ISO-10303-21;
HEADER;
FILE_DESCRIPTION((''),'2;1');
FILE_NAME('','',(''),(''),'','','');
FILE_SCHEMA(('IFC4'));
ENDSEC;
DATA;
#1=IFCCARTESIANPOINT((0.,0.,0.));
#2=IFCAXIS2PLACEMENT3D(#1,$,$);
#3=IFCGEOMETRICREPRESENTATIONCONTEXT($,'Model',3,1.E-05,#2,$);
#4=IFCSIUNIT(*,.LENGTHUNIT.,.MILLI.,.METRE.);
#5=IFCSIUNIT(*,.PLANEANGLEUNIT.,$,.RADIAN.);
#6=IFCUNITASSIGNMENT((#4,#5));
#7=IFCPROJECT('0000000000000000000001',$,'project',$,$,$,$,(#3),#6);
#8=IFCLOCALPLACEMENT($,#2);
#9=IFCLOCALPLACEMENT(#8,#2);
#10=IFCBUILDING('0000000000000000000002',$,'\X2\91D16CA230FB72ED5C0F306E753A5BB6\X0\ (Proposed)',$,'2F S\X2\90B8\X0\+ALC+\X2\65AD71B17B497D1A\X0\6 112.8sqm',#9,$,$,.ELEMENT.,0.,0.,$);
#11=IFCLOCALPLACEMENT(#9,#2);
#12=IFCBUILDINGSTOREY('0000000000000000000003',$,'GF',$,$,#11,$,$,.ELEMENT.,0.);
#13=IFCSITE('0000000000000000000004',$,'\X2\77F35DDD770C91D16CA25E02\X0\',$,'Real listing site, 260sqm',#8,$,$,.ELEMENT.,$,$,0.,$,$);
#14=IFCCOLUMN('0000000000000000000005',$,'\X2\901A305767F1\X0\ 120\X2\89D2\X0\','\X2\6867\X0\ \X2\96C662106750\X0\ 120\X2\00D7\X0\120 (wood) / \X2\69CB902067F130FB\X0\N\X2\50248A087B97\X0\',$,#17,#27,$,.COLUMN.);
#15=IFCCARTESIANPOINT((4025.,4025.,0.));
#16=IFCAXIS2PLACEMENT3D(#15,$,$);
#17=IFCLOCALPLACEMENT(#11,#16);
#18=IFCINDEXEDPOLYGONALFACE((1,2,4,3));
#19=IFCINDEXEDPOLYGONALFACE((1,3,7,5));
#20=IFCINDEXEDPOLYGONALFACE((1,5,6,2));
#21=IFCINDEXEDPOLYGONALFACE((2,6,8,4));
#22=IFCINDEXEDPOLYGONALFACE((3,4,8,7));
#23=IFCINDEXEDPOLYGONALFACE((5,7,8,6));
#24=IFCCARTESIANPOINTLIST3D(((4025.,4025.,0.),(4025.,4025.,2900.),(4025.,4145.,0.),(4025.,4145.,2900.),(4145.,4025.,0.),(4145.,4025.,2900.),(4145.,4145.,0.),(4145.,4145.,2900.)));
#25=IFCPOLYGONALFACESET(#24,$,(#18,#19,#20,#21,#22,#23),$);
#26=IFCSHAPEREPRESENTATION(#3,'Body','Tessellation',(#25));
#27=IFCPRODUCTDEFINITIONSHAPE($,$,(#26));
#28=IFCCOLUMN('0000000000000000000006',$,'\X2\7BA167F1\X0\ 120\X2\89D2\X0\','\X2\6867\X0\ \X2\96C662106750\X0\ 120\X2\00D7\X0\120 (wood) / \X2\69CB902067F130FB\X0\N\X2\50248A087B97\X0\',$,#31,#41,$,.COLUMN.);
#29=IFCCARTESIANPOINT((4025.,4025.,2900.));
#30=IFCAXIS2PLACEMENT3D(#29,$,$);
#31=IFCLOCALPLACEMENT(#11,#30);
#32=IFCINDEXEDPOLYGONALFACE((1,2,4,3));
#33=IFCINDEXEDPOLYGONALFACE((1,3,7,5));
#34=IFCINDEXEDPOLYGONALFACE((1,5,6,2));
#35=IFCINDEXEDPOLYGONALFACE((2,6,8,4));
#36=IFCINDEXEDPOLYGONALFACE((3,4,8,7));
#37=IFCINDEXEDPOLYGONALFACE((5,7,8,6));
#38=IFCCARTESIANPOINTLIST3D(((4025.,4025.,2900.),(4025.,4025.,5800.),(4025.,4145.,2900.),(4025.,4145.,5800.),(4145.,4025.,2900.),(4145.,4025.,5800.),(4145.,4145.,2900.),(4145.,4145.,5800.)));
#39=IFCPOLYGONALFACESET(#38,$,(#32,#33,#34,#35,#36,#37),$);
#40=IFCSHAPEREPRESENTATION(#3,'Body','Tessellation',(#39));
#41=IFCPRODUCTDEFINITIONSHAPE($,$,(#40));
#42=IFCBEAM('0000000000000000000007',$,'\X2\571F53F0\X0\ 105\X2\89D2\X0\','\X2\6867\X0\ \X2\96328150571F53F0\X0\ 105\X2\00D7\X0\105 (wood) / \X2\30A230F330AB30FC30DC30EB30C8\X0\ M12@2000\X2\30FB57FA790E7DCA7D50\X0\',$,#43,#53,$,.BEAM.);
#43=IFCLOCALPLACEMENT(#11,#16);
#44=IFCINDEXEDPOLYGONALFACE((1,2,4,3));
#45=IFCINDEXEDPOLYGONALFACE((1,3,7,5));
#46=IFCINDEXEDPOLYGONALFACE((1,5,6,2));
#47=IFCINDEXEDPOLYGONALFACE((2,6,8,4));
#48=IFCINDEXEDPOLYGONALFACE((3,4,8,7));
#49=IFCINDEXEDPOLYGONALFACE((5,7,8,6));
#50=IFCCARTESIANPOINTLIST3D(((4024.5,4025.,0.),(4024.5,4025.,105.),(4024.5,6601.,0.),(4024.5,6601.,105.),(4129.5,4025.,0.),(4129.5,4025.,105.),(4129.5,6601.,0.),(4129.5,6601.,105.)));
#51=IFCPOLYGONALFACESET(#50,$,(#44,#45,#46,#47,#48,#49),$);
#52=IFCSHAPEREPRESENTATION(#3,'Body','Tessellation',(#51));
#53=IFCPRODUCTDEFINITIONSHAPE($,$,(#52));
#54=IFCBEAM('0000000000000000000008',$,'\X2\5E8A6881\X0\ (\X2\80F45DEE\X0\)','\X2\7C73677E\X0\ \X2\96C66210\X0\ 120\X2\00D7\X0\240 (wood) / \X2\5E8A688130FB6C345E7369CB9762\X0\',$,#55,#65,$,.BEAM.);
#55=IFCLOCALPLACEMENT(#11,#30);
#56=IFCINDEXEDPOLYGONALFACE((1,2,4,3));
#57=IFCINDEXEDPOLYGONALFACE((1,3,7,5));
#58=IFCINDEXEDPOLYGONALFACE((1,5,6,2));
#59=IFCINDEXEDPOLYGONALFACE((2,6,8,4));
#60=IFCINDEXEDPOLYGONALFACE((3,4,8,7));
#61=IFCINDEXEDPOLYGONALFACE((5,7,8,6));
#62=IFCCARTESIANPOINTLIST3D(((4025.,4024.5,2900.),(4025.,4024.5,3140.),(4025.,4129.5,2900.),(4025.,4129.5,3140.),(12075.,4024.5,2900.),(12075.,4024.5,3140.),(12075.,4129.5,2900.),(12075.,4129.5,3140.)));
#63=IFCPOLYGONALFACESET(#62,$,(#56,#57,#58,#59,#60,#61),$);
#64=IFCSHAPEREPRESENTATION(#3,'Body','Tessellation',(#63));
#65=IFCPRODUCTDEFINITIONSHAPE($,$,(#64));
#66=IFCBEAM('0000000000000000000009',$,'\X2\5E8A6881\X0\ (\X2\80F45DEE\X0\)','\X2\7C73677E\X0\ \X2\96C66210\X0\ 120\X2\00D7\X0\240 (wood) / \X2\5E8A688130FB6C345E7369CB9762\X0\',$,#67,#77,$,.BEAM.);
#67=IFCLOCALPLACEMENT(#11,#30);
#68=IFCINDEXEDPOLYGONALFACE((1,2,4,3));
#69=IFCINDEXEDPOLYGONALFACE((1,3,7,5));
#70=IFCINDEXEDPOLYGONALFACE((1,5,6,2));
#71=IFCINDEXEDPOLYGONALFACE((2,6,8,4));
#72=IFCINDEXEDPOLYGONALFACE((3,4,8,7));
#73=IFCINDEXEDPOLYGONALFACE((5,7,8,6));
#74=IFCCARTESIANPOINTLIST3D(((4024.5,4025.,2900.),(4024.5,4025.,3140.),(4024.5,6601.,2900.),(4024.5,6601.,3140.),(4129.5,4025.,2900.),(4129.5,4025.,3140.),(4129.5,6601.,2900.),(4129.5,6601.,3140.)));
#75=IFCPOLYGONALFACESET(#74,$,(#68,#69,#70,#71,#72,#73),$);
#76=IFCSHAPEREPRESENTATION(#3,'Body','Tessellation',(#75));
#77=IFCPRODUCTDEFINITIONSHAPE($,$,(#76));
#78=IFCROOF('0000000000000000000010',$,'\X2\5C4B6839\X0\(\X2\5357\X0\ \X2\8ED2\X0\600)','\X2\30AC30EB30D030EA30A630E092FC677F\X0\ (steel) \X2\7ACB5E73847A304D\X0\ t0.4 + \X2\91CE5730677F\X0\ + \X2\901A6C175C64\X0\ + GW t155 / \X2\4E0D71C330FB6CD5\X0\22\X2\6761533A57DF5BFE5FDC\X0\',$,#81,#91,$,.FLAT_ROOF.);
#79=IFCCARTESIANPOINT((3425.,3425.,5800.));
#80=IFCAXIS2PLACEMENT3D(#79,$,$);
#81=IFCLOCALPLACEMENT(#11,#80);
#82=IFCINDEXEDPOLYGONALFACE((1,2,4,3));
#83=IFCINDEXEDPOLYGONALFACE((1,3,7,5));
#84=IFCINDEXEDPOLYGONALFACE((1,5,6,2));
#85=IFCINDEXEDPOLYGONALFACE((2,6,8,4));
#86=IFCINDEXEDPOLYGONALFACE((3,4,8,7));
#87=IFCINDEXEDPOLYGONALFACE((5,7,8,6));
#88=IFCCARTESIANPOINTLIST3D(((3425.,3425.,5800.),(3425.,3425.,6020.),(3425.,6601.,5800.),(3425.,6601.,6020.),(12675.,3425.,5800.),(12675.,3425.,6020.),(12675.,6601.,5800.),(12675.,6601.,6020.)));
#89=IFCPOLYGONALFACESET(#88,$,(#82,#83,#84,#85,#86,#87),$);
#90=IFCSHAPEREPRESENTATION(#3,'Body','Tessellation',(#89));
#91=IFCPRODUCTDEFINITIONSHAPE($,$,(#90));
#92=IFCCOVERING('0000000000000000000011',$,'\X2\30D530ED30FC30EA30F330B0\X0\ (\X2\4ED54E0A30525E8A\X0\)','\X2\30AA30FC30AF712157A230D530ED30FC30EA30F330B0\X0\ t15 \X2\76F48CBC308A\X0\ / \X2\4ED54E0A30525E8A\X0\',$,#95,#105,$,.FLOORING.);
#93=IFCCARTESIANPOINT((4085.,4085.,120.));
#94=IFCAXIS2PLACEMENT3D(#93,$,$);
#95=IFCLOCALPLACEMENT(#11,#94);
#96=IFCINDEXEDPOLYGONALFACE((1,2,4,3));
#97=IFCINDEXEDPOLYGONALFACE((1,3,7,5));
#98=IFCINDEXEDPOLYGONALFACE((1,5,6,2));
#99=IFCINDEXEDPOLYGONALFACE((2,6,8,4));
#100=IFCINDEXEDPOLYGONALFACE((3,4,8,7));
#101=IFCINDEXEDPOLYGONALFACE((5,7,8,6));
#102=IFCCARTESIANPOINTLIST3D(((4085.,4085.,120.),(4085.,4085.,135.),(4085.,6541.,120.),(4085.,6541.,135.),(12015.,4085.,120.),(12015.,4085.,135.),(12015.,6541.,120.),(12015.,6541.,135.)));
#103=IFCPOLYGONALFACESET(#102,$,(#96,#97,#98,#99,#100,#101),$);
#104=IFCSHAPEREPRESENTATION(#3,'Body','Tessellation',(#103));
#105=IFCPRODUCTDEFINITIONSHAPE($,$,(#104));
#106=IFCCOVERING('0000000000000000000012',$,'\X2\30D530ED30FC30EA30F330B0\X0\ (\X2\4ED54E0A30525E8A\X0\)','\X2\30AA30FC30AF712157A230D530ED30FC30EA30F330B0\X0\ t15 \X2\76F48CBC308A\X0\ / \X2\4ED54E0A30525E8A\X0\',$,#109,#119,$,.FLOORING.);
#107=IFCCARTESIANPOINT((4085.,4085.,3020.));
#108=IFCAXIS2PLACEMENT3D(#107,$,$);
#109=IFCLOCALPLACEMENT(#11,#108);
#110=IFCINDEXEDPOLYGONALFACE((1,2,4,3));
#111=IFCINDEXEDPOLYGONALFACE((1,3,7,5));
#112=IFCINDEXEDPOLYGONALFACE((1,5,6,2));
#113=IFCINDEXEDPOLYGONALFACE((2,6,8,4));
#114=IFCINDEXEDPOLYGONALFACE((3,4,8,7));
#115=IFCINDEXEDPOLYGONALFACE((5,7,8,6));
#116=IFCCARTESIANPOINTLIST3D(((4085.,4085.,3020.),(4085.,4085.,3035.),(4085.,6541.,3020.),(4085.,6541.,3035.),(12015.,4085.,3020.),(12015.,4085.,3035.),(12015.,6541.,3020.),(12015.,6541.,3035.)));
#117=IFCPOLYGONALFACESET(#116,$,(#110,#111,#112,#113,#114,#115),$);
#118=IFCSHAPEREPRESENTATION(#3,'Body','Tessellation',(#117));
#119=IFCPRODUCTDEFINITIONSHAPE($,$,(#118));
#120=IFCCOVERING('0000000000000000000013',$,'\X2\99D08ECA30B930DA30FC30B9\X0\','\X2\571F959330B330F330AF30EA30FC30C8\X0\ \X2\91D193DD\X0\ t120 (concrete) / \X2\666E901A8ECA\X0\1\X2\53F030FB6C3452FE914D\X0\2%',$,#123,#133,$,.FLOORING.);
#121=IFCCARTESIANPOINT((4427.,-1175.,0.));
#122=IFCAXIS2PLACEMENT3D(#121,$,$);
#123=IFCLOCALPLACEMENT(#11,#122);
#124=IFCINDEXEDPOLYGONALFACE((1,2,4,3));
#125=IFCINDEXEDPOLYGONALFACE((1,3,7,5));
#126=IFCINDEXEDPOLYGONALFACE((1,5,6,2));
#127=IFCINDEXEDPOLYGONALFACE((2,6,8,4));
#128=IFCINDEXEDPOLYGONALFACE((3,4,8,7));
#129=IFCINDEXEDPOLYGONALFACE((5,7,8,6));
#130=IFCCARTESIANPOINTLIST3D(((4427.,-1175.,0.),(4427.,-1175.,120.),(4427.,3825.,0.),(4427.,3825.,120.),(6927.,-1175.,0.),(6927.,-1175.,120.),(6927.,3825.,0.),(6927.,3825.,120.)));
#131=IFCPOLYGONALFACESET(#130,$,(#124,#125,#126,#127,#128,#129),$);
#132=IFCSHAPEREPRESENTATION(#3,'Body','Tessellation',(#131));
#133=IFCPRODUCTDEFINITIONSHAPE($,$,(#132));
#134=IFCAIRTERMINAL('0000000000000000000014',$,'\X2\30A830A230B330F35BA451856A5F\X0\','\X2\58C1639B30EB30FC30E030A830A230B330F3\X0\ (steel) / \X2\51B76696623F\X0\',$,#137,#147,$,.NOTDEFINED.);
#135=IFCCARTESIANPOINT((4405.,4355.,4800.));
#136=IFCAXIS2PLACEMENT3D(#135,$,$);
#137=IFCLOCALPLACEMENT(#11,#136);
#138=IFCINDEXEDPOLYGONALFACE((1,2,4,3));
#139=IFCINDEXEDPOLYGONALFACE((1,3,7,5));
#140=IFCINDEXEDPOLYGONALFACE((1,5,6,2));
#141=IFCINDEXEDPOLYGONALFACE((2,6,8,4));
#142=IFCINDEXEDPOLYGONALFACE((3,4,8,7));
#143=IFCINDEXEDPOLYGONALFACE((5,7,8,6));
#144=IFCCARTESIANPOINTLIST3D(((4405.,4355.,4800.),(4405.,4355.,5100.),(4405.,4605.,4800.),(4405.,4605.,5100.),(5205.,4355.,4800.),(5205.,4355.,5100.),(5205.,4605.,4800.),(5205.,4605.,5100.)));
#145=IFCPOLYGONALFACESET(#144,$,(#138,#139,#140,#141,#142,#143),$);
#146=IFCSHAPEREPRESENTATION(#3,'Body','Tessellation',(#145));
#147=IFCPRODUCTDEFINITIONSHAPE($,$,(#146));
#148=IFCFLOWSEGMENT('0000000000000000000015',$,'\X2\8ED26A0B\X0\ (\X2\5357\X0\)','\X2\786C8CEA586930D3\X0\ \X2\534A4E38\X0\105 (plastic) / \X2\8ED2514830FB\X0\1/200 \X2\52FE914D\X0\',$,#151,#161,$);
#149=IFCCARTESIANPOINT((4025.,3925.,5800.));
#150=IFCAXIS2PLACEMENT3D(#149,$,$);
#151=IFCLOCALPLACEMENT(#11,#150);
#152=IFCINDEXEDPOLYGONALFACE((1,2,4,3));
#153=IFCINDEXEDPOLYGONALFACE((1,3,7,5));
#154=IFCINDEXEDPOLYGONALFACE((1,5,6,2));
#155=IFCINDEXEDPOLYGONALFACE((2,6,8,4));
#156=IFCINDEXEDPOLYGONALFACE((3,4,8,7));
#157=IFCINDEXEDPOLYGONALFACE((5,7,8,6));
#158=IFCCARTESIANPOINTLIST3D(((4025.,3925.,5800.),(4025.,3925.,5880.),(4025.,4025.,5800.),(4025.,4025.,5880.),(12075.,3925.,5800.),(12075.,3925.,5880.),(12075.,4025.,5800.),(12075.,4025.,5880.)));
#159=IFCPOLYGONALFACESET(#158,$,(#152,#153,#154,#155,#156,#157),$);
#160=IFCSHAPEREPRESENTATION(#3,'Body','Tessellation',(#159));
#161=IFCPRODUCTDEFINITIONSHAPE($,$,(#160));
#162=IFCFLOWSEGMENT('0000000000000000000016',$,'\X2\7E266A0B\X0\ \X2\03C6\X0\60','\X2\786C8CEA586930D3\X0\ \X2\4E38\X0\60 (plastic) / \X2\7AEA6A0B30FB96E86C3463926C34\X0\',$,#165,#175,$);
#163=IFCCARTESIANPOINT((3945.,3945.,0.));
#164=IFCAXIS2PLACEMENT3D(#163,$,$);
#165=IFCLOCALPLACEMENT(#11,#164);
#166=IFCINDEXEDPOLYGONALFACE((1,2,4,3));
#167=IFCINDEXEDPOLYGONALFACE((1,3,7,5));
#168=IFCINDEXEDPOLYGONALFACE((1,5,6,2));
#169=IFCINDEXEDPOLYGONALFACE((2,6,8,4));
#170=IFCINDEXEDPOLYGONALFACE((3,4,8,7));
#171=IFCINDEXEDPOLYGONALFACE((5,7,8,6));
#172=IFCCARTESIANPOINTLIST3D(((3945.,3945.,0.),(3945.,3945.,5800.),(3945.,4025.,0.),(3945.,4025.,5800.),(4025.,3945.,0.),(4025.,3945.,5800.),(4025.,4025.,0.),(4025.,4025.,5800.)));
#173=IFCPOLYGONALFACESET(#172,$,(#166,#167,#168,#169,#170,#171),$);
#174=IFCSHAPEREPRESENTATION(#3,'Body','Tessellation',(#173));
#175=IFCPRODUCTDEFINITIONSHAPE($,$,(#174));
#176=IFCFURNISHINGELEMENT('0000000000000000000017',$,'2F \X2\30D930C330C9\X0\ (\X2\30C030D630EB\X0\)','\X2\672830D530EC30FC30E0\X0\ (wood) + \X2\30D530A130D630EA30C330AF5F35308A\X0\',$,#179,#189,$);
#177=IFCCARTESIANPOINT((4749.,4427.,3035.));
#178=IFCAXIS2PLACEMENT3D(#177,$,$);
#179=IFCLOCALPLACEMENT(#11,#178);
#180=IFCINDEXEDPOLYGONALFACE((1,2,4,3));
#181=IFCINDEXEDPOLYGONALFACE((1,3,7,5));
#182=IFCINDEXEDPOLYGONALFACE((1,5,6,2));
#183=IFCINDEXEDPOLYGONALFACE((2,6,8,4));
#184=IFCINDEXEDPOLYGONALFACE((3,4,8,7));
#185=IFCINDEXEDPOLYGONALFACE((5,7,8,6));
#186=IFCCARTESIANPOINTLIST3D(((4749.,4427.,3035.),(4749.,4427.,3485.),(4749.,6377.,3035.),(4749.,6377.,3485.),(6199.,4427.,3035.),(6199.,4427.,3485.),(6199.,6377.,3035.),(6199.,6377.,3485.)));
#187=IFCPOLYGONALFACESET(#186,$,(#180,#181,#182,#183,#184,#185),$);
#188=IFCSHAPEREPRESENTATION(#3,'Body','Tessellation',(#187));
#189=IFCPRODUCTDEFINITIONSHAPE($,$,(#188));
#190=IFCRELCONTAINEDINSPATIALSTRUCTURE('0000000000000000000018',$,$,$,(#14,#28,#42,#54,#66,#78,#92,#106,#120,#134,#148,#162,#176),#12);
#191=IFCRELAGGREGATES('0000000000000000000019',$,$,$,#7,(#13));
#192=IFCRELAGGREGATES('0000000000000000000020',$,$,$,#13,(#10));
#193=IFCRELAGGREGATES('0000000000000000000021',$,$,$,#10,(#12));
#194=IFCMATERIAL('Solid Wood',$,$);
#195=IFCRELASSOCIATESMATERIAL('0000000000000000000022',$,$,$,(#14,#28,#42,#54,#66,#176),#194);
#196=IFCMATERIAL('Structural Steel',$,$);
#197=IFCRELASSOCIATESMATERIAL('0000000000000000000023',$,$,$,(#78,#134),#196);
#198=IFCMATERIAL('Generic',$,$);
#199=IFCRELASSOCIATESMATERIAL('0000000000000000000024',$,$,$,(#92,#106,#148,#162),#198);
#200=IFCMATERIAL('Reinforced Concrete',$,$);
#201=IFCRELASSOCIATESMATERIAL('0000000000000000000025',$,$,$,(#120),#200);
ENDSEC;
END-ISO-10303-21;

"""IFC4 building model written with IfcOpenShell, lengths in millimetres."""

from ifc_helpers import new_model, si_unit, frame, frame_2d, origin, place, context, project, spatial, rectangle, extrude, material, element, save


model = new_model("IFC4")

# Units and contexts
model_context = context("Model", 3, precision=1e-05, world=origin())
ifc_project = project(units=[si_unit("LENGTHUNIT", "METRE", prefix="MILLI"), si_unit("PLANEANGLEUNIT", "RADIAN")], contexts=[model_context])

# Site, building, storey
site_placement = place(None, origin())
site = spatial("IfcSite", under=ifc_project, at=site_placement, Name="石川県金沢市", ObjectType="Real listing site, 260sqm", CompositionType="ELEMENT", RefElevation=0.0)
building_placement = place(site_placement, origin())
building = spatial("IfcBuilding", under=site, at=building_placement, Name="金沢・狭小の町家 (Proposed)", ObjectType="2F S邸+ALC+断熱等級6 112.8sqm", CompositionType="ELEMENT", ElevationOfRefHeight=0.0, ElevationOfTerrain=0.0)
storey_placement = place(building_placement, origin())
storey = spatial("IfcBuildingStorey", under=building, at=storey_placement, Name="GF", CompositionType="ELEMENT", Elevation=0.0)

# Columns
ifc_material_1 = material(Name="Solid Wood")
column_1_placement = place(storey_placement, frame((4025.0, 4025.0, 0.0)))
element("IfcColumn", 1, at=column_1_placement, inside=storey, material=ifc_material_1, Name="通し柱 120角", Description="桧 集成材 120×120 (wood) / 構造柱・N値計算", PredefinedType="COLUMN", context=model_context, shape_type="SweptSolid", body=[
    extrude(rectangle(XDim=120.0, YDim=120.0, at=frame_2d((60.0, 60.0))), frame((4025.0, 4025.0, 0.0)), (0.0, 0.0, 1.0), 2900.0),
])
column_2_placement = place(storey_placement, frame((4025.0, 4025.0, 2900.0)))
element("IfcColumn", 2, at=column_2_placement, inside=storey, material=ifc_material_1, Name="管柱 120角", Description="桧 集成材 120×120 (wood) / 構造柱・N値計算", PredefinedType="COLUMN", context=model_context, shape_type="SweptSolid", body=[
    extrude(rectangle(XDim=120.0, YDim=120.0, at=frame_2d((60.0, 60.0))), frame((4025.0, 4025.0, 2900.0)), (0.0, 0.0, 1.0), 2900.0),
])

# Beams
beam_1_placement = place(storey_placement, frame((4025.0, 4025.0, 0.0)))
element("IfcBeam", 3, at=beam_1_placement, inside=storey, material=ifc_material_1, Name="土台 105角", Description="桧 防腐土台 105×105 (wood) / アンカーボルト M12@2000・基礎緊結", PredefinedType="BEAM", context=model_context, shape_type="SweptSolid", body=[
    extrude(rectangle(XDim=105.0, YDim=2576.0, at=frame_2d((52.0, 1288.0))), frame((4025.0, 4025.0, 0.0)), (0.0, 0.0, 1.0), 105.0),
])
beam_2_placement = place(storey_placement, frame((4025.0, 4025.0, 2900.0)))
element("IfcBeam", 4, at=beam_2_placement, inside=storey, material=ifc_material_1, Name="床梁 (胴差)", Description="米松 集成 120×240 (wood) / 床梁・水平構面", PredefinedType="BEAM", context=model_context, shape_type="SweptSolid", body=[
    extrude(rectangle(XDim=8050.0, YDim=105.0, at=frame_2d((4025.0, 52.0))), frame((4025.0, 4025.0, 2900.0)), (0.0, 0.0, 1.0), 240.0),
])
beam_3_placement = place(storey_placement, frame((4025.0, 4025.0, 2900.0)))
element("IfcBeam", 5, at=beam_3_placement, inside=storey, material=ifc_material_1, Name="床梁 (胴差)", Description="米松 集成 120×240 (wood) / 床梁・水平構面", PredefinedType="BEAM", context=model_context, shape_type="SweptSolid", body=[
    extrude(rectangle(XDim=105.0, YDim=2576.0, at=frame_2d((52.0, 1288.0))), frame((4025.0, 4025.0, 2900.0)), (0.0, 0.0, 1.0), 240.0),
])

# Shared definitions
ifc_material_2 = material(Name="Reinforced Concrete")

# Roof
ifc_material_3 = material(Name="Structural Steel")
for number, where, name in (
    (6, (3425.0, 3425.0, 5800.0), "屋根(南 軒600)"),
):
    element("IfcRoof", number, at=place(storey_placement, frame(where)), inside=storey, material=ifc_material_3, Name=name, Description="ガルバリウム鋼板 (steel) 立平葺き t0.4 + 野地板 + 通気層 + GW t155 / 不燃・法22条区域対応", PredefinedType="FLAT_ROOF", context=model_context, shape_type="SweptSolid", body=[
        extrude(rectangle(XDim=9250.0, YDim=3176.0, at=frame_2d((4625.0, 1588.0))), frame((3425.0, 3425.0, 5800.0)), (0.0, 0.0, 1.0), 220.0),
    ])

# Coverings
ifc_material_4 = material(Name="Generic")
covering_1_placement = place(storey_placement, frame((4085.0, 4085.0, 120.0)))
element("IfcCovering", 7, at=covering_1_placement, inside=storey, material=ifc_material_4, Name="フローリング (仕上げ床)", Description="オーク無垢フローリング t15 直貼り / 仕上げ床", PredefinedType="FLOORING", context=model_context, shape_type="SweptSolid", body=[
    extrude(rectangle(XDim=7930.0, YDim=2456.0, at=frame_2d((3965.0, 1228.0))), frame((4085.0, 4085.0, 120.0)), (0.0, 0.0, 1.0), 15.0),
])
covering_2_placement = place(storey_placement, frame((4085.0, 4085.0, 3020.0)))
element("IfcCovering", 8, at=covering_2_placement, inside=storey, material=ifc_material_4, Name="フローリング (仕上げ床)", Description="オーク無垢フローリング t15 直貼り / 仕上げ床", PredefinedType="FLOORING", context=model_context, shape_type="SweptSolid", body=[
    extrude(rectangle(XDim=7930.0, YDim=2456.0, at=frame_2d((3965.0, 1228.0))), frame((4085.0, 4085.0, 3020.0)), (0.0, 0.0, 1.0), 15.0),
])
covering_3_placement = place(storey_placement, frame((4427.0, -1175.0, 0.0)))
element("IfcCovering", 9, at=covering_3_placement, inside=storey, material=ifc_material_2, Name="駐車スペース", Description="土間コンクリート 金鏝 t120 (concrete) / 普通車1台・水勾配2%", PredefinedType="FLOORING", context=model_context, shape_type="SweptSolid", body=[
    extrude(rectangle(XDim=2500.0, YDim=5000.0, at=frame_2d((1250.0, 2500.0))), frame((4427.0, -1175.0, 0.0)), (0.0, 0.0, 1.0), 120.0),
])

# Air terminal
air_terminal_placement = place(storey_placement, frame((4405.0, 4355.0, 4800.0)))
element("IfcAirTerminal", 10, at=air_terminal_placement, inside=storey, material=ifc_material_3, Name="エアコン室内機", Description="壁掛ルームエアコン (steel) / 冷暖房", PredefinedType="NOTDEFINED", context=model_context, shape_type="SweptSolid", body=[
    extrude(rectangle(XDim=800.0, YDim=250.0, at=frame_2d((400.0, 125.0))), frame((4405.0, 4355.0, 4800.0)), (0.0, 0.0, 1.0), 300.0),
])

# Flow segments
flow_segment_1_placement = place(storey_placement, frame((4025.0, 3925.0, 5800.0)))
element("IfcFlowSegment", 11, at=flow_segment_1_placement, inside=storey, material=ifc_material_4, Name="軒樋 (南)", Description="硬質塩ビ 半丸105 (plastic) / 軒先・1/200 勾配", context=model_context, shape_type="SweptSolid", body=[
    extrude(rectangle(XDim=8050.0, YDim=100.0, at=frame_2d((4025.0, 50.0))), frame((4025.0, 3925.0, 5800.0)), (0.0, 0.0, 1.0), 80.0),
])
flow_segment_2_placement = place(storey_placement, frame((3945.0, 3945.0, 0.0)))
element("IfcFlowSegment", 12, at=flow_segment_2_placement, inside=storey, material=ifc_material_4, Name="縦樋 φ60", Description="硬質塩ビ 丸60 (plastic) / 竪樋・雨水排水", context=model_context, shape_type="SweptSolid", body=[
    extrude(rectangle(XDim=80.0, YDim=80.0, at=frame_2d((40.0, 40.0))), frame((3945.0, 3945.0, 0.0)), (0.0, 0.0, 1.0), 5800.0),
])

# Furnishing element
furnishing_placement = place(storey_placement, frame((4749.0, 4427.0, 3035.0)))
element("IfcFurnishingElement", 13, at=furnishing_placement, inside=storey, material=ifc_material_1, Name="2F ベッド (ダブル)", Description="木フレーム (wood) + ファブリック張り", context=model_context, shape_type="SweptSolid", body=[
    extrude(rectangle(XDim=1450.0, YDim=1950.0, at=frame_2d((725.0, 975.0))), frame((4749.0, 4427.0, 3035.0)), (0.0, 0.0, 1.0), 450.0),
])

save(model, "model.ifc")
